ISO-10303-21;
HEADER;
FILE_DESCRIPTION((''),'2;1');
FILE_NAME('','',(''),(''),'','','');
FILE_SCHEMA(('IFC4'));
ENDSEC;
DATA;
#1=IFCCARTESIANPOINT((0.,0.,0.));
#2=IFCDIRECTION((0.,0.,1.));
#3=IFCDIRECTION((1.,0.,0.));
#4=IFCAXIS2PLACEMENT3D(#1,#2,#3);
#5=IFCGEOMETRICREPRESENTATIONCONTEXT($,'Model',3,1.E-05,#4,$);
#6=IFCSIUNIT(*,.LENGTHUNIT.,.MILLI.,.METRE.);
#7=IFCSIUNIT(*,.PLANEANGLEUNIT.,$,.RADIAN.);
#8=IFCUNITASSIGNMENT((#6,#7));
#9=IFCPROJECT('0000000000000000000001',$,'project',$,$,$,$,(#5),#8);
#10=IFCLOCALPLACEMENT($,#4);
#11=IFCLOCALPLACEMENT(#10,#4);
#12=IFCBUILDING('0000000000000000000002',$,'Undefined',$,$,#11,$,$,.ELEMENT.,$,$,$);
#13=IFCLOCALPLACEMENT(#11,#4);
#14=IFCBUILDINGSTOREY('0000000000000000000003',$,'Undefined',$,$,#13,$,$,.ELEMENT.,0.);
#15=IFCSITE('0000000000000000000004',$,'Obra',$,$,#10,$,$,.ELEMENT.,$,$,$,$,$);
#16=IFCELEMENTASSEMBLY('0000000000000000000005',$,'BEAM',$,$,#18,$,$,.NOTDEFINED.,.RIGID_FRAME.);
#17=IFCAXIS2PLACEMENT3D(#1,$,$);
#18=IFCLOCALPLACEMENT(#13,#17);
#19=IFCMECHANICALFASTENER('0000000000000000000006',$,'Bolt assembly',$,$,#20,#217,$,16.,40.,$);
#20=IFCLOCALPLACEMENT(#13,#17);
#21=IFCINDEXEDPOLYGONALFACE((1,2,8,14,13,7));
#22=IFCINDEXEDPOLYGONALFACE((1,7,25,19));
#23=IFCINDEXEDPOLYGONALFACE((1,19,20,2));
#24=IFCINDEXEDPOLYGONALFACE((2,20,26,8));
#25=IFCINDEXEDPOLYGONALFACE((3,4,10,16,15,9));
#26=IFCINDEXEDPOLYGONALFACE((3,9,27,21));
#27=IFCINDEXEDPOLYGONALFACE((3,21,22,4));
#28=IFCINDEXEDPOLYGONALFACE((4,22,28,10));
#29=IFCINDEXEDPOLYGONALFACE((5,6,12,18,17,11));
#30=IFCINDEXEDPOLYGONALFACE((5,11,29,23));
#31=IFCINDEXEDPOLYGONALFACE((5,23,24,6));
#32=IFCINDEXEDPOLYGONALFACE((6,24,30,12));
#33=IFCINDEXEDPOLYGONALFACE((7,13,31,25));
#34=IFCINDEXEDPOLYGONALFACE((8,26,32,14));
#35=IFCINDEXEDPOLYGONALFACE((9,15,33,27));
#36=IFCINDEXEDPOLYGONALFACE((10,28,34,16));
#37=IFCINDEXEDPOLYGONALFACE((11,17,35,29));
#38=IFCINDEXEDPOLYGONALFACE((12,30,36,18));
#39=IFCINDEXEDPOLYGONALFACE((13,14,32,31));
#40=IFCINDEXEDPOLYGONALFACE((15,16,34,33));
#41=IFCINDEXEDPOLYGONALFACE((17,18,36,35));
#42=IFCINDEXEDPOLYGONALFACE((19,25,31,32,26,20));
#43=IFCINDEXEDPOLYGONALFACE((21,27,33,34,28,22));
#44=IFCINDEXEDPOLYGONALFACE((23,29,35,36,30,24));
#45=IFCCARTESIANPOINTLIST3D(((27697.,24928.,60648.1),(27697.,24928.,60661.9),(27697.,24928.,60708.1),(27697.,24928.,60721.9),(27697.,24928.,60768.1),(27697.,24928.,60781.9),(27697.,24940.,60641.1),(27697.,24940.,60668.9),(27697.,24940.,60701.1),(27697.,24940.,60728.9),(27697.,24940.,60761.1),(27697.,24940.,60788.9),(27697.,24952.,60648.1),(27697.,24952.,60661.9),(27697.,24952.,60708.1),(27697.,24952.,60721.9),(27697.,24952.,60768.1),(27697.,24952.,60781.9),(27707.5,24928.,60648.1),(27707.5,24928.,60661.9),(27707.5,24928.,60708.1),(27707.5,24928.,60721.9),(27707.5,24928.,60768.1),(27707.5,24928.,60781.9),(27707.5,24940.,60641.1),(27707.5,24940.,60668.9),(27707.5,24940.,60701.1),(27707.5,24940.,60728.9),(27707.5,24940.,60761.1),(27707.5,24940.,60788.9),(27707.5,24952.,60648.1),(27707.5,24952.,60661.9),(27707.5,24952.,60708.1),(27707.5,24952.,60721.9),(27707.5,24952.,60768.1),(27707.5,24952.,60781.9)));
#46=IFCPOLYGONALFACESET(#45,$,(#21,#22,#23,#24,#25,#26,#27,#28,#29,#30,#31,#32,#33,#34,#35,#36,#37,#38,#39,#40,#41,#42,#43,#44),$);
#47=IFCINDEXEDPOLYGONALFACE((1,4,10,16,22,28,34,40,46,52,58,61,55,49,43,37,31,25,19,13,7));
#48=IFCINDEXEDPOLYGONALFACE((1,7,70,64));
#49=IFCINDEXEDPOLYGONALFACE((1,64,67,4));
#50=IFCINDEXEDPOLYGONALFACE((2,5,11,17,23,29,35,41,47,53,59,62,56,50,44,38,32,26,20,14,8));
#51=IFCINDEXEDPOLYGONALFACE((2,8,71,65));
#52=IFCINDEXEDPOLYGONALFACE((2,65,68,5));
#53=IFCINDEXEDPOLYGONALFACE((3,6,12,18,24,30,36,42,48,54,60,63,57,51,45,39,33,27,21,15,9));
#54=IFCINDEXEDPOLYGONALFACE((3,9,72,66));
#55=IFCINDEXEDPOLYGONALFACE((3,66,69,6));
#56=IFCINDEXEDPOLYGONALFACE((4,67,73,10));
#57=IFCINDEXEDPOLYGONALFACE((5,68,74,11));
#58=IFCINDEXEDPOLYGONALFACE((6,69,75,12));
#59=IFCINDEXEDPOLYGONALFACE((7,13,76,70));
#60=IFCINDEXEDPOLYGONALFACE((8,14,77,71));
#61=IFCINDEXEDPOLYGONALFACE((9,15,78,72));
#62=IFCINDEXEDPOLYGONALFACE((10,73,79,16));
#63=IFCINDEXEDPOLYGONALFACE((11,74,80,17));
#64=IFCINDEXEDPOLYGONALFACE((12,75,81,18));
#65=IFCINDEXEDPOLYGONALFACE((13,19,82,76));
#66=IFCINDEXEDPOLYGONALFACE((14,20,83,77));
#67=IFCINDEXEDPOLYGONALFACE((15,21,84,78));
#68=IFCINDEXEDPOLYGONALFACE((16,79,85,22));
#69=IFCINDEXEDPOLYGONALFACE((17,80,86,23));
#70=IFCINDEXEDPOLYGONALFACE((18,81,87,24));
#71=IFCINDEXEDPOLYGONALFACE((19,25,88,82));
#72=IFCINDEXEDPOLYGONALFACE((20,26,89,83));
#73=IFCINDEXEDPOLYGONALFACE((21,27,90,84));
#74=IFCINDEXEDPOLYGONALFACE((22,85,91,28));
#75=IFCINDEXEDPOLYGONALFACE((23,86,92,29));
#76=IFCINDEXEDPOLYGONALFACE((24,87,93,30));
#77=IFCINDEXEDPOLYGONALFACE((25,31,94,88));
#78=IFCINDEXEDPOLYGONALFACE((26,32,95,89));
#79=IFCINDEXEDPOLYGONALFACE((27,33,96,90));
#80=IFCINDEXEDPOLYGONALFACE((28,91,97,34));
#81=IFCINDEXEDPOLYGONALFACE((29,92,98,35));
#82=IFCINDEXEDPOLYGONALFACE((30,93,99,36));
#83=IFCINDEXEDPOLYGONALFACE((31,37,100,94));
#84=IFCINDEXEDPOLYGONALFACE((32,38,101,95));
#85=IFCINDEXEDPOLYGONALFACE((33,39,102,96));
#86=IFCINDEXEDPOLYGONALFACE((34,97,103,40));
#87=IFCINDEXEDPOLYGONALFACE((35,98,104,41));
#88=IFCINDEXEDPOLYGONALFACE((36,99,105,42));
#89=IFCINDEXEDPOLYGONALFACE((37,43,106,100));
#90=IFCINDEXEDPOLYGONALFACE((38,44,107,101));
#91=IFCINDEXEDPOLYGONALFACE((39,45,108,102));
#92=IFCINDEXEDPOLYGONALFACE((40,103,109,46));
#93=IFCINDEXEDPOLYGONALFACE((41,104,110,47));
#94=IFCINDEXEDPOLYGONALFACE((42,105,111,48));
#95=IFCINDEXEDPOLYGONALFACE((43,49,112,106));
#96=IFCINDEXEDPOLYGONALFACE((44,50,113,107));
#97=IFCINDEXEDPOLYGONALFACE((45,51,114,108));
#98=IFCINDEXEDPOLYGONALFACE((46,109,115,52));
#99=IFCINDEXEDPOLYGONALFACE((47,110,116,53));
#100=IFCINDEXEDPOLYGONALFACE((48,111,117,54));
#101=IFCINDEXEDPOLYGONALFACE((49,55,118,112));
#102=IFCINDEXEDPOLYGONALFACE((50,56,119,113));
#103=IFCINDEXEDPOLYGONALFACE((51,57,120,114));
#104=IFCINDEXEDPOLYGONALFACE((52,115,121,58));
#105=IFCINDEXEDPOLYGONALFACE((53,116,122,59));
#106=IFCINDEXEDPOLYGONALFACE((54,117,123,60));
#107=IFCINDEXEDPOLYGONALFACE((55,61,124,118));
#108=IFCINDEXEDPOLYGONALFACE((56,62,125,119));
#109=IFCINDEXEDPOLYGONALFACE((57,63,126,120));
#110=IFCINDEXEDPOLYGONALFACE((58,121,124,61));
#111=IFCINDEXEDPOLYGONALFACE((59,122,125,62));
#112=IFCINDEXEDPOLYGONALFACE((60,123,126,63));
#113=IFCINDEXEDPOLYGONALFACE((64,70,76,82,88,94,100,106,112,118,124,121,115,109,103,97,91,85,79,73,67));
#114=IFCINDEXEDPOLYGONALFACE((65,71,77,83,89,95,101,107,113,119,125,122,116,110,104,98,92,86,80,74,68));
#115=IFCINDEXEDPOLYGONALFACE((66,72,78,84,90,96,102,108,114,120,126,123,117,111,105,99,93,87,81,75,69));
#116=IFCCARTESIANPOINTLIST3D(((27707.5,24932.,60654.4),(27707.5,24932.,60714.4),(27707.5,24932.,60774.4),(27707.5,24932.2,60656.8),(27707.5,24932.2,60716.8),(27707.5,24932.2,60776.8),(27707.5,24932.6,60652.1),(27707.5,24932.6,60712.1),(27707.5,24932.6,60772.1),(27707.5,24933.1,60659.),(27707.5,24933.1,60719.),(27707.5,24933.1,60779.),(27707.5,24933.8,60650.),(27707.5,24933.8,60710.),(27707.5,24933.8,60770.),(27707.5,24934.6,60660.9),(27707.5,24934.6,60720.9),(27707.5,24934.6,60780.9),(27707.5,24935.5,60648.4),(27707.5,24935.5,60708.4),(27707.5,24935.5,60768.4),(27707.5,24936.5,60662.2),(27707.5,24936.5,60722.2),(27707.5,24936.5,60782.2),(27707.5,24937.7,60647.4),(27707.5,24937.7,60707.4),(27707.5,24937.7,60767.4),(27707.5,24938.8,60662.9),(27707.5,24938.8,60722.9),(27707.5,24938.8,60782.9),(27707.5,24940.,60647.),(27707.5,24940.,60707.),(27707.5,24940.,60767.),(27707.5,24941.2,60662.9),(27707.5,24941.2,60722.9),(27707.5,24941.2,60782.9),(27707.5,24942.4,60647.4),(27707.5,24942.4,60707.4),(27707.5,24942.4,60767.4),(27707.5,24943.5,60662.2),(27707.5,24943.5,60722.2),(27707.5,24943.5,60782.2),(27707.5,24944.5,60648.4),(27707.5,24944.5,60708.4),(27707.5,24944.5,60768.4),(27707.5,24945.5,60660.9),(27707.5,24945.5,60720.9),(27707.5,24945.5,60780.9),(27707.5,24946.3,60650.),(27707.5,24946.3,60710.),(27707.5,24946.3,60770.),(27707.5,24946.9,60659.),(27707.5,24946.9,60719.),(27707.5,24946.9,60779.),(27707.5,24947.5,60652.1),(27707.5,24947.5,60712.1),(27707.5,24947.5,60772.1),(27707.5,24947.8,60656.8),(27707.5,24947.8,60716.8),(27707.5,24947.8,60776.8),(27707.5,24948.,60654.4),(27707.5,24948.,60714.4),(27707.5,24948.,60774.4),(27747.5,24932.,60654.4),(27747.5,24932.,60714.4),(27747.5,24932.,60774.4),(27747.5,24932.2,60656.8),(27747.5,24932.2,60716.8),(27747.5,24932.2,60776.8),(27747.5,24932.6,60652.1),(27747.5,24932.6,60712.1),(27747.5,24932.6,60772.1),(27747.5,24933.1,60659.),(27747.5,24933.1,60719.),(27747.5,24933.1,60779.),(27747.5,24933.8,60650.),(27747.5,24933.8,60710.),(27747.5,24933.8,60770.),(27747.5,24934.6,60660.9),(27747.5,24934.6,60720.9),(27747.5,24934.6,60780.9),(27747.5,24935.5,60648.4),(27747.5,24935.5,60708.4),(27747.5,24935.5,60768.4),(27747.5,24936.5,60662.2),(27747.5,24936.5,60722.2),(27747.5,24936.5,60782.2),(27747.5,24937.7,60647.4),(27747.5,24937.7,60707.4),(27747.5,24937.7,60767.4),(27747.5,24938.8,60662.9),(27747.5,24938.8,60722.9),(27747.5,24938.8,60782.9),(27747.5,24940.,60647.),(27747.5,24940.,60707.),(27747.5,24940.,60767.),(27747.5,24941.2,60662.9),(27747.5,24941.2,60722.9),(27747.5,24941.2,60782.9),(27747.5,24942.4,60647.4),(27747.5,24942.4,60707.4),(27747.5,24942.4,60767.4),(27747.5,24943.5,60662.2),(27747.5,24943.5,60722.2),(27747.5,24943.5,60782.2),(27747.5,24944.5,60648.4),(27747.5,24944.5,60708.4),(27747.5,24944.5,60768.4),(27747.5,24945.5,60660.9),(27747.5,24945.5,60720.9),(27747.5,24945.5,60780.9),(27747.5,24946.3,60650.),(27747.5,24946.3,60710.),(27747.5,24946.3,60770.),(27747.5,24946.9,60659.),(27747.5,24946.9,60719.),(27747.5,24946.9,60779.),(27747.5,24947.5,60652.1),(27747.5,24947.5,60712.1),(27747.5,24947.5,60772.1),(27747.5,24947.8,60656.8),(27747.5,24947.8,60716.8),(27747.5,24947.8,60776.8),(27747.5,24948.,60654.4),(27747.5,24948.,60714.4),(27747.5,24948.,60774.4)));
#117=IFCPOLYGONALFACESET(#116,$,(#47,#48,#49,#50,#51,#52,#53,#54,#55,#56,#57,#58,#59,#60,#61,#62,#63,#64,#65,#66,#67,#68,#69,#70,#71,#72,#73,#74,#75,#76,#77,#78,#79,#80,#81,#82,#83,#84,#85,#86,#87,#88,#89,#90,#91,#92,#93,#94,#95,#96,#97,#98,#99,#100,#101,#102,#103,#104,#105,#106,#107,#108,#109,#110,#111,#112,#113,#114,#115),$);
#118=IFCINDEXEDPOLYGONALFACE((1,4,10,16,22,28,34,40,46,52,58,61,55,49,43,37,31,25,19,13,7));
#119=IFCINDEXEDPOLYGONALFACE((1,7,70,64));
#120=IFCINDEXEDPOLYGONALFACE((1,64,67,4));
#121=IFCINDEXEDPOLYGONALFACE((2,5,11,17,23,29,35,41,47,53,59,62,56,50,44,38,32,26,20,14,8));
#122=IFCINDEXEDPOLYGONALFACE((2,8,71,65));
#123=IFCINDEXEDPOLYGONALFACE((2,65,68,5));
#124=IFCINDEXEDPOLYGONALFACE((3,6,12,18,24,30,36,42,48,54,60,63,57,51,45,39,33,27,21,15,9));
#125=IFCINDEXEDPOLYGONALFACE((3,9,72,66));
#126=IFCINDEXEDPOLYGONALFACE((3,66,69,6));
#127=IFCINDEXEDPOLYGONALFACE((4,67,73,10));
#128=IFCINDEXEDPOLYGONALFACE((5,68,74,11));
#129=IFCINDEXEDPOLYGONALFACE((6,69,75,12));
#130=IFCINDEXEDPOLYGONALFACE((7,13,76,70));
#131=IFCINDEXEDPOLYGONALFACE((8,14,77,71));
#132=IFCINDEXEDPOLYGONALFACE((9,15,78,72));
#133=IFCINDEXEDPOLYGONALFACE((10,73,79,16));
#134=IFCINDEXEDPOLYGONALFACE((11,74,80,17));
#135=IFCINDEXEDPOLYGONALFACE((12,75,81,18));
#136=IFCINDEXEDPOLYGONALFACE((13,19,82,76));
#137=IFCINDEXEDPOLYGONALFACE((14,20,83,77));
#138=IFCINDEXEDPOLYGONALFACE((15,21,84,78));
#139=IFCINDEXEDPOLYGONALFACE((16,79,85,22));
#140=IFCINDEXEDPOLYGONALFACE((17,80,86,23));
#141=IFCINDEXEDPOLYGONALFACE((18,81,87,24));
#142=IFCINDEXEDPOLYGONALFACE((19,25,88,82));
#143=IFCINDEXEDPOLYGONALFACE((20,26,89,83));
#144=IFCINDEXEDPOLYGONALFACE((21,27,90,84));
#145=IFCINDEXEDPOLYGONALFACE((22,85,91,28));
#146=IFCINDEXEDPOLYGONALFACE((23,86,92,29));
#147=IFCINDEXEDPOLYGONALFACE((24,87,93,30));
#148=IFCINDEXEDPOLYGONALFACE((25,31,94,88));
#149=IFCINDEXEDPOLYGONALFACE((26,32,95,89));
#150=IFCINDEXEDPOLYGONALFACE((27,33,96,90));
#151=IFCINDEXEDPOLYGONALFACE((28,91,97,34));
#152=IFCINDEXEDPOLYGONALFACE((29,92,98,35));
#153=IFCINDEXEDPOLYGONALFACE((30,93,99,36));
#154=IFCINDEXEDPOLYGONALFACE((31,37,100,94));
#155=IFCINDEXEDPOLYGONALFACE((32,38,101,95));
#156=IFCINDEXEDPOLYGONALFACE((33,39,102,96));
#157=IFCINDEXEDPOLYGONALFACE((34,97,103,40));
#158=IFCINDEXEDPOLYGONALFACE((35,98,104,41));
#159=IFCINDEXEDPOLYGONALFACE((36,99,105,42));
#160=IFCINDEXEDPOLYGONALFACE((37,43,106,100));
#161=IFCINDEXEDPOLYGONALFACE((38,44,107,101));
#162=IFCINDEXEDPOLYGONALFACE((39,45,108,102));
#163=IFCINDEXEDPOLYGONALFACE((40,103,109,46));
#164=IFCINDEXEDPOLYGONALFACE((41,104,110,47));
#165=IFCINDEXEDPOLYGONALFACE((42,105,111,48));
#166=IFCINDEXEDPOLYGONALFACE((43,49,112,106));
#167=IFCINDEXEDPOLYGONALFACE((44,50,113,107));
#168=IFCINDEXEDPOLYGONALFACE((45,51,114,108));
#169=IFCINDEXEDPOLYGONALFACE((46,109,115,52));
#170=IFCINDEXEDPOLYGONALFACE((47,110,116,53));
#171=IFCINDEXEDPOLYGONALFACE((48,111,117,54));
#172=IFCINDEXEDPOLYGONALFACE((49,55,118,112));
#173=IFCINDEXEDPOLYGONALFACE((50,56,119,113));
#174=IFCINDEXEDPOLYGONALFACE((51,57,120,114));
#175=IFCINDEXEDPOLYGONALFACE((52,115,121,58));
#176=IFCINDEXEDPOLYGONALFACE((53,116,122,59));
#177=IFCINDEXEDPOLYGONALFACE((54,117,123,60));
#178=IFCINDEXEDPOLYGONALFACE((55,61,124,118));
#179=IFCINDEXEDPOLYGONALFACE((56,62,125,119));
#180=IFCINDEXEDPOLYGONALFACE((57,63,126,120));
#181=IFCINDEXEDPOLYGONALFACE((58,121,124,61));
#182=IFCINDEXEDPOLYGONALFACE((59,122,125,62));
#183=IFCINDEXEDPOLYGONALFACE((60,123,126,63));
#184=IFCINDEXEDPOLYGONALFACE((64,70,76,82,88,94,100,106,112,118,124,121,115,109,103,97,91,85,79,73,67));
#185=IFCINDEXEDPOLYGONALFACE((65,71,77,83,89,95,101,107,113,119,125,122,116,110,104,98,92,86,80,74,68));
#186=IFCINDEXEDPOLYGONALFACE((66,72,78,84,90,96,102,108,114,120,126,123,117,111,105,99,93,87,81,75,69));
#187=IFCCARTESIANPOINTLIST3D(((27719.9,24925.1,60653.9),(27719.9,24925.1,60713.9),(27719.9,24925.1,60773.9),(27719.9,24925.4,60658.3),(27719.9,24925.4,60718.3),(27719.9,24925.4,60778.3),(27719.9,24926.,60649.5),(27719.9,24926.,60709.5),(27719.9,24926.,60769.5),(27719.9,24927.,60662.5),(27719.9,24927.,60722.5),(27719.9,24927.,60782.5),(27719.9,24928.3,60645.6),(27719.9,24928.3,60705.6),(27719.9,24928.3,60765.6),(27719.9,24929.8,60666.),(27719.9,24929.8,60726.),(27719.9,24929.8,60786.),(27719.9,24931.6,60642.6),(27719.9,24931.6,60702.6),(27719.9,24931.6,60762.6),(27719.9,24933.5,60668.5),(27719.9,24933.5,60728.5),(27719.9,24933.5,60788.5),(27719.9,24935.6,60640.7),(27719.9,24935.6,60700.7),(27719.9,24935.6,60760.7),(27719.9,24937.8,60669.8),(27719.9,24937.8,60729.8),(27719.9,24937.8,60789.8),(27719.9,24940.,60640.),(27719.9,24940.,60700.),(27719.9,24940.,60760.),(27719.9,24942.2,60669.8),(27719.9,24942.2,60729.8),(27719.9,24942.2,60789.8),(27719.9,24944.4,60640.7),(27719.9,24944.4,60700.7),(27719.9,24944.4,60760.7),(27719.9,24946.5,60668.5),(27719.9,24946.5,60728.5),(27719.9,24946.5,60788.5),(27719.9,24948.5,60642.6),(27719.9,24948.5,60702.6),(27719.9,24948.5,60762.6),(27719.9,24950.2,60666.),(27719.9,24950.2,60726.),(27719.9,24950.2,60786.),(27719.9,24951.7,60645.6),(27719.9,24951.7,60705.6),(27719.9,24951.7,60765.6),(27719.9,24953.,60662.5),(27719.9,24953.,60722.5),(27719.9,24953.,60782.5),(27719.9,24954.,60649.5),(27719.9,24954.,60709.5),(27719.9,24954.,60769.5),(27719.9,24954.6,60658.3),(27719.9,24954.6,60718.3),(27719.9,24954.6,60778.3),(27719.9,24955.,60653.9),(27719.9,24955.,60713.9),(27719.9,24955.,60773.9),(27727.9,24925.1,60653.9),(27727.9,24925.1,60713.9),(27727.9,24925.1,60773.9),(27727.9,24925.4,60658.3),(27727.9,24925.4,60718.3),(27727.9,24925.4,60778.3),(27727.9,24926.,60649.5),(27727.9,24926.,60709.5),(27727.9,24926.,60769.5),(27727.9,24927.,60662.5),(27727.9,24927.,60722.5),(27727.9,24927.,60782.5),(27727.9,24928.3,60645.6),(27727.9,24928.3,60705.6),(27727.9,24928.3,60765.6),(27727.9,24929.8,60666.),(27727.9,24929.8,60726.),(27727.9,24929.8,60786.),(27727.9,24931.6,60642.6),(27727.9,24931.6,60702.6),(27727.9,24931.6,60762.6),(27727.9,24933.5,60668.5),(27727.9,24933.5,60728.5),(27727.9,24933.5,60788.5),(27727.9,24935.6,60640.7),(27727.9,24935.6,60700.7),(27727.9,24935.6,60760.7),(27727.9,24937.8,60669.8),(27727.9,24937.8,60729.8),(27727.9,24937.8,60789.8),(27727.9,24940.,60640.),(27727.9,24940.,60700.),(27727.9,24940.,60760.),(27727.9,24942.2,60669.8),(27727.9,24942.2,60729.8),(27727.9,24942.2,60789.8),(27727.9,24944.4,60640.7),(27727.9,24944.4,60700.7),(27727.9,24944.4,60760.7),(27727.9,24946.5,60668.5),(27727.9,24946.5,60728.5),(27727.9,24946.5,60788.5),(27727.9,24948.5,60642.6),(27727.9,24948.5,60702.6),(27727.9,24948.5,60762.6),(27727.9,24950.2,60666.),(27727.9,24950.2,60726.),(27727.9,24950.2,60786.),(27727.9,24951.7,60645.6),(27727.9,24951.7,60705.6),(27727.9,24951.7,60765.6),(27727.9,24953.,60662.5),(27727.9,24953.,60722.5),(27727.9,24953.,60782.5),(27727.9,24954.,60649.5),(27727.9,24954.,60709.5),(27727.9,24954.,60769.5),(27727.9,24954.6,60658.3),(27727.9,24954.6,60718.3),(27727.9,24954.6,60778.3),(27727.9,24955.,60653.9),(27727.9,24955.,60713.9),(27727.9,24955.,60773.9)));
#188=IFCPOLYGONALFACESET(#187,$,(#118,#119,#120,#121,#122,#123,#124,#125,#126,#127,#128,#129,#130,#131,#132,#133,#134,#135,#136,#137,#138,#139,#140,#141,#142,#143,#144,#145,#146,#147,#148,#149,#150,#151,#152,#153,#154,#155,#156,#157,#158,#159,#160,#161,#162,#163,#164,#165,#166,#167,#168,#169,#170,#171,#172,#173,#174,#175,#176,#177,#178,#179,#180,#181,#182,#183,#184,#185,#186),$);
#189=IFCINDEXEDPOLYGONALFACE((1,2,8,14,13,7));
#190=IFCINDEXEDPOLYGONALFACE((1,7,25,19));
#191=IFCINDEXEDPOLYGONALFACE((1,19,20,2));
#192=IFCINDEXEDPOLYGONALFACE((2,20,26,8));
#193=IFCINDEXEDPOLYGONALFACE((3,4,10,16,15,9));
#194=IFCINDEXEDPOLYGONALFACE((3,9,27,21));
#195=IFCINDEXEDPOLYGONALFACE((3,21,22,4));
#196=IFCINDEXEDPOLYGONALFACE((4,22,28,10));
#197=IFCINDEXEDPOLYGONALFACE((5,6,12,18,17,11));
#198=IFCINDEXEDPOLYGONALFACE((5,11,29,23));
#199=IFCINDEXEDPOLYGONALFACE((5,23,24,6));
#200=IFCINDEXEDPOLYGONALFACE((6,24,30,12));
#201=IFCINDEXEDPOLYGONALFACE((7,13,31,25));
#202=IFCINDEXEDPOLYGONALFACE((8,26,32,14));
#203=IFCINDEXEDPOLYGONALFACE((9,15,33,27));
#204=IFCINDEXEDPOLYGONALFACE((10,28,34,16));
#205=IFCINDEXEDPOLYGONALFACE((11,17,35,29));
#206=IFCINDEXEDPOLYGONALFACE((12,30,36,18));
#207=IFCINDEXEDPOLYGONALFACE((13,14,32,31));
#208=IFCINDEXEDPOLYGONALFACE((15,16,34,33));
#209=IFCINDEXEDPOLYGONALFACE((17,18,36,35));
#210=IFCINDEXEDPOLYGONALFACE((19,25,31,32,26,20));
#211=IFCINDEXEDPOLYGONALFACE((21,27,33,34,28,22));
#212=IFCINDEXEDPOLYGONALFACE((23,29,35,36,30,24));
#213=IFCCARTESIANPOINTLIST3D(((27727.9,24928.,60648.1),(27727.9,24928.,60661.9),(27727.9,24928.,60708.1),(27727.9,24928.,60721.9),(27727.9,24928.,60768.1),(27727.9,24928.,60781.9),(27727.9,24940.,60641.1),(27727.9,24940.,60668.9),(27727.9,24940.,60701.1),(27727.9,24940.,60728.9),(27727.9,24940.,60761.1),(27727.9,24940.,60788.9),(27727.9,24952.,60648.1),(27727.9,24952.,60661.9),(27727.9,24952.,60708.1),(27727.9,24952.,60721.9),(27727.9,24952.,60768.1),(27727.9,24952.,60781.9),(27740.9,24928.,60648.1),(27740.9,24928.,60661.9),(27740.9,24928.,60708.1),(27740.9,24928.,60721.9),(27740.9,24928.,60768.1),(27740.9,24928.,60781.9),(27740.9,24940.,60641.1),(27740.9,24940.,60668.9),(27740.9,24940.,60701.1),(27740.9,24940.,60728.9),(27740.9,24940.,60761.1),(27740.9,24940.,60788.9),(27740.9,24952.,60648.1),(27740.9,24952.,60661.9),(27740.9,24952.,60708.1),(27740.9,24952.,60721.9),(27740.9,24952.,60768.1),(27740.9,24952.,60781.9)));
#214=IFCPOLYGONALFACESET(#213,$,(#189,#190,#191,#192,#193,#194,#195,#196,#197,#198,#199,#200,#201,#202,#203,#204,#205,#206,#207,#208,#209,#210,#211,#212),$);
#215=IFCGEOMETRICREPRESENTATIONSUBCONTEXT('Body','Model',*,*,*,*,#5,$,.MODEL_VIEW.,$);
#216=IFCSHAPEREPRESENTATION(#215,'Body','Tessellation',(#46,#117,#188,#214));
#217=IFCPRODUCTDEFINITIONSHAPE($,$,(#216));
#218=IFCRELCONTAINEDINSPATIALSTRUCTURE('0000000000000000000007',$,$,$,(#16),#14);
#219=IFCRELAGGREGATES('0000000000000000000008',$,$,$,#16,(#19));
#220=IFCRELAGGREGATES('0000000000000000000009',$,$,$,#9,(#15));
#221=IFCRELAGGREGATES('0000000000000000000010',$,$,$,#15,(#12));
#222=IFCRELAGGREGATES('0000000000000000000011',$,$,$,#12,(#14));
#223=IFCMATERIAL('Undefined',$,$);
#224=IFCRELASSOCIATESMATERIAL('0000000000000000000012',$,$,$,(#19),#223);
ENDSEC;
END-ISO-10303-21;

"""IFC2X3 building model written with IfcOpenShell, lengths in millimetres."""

from ifc_helpers import new_model, si_unit, frame, origin_with_axes, origin_2d_with_axis, place, context, subcontext, project, spatial, polyline, circle, outline, extrude, source, transform, mapped, material, element, aggregate, save


model = new_model("IFC2X3")

# Units and contexts
model_context = context("Model", 3, precision=1e-05, world=origin_with_axes())
body_context = subcontext(model_context, "Body", "Model", "MODEL_VIEW")
ifc_project = project(units=[si_unit("LENGTHUNIT", "METRE", prefix="MILLI"), si_unit("PLANEANGLEUNIT", "RADIAN")], contexts=[model_context])

# Site, building, storey
site_placement = place(None, origin_with_axes())
site = spatial("IfcSite", under=ifc_project, at=site_placement, Name="Obra", CompositionType="ELEMENT")
building_placement = place(site_placement, origin_with_axes())
building = spatial("IfcBuilding", under=site, at=building_placement, Name="Undefined", CompositionType="ELEMENT")
storey_placement = place(building_placement, origin_with_axes())
storey = spatial("IfcBuildingStorey", under=building, at=storey_placement, Name="Undefined", CompositionType="ELEMENT", Elevation=0.0)

# Shared definitions
ifc_material_1 = material(Name="Undefined")

# Element assembly, mechanical fastener
assembly_1_placement = place(storey_placement, origin_with_axes())
assembly_1 = element("IfcElementAssembly", 1, at=assembly_1_placement, inside=storey, Name="BEAM", AssemblyPlace="NOTDEFINED", PredefinedType="RIGID_FRAME")
shared_shape_1 = source(origin_with_axes(), body_context, "Body", "SweptSolid", [
    extrude(outline(polyline([(13.9, 0.0), (6.9, 12.0), (-6.9, 12.0), (-13.9, 0.0), (-6.9, -12.0), (6.9, -12.0), (13.9, 0.0)])), frame((0.0, -19.7, 0.0), z_axis=(0.0, 1.0, 0.0), x_axis=(1.0, 0.0, 0.0)), (0.0, 0.0, 1.0), 10.6),
    extrude(circle(Radius=8.0, at=origin_2d_with_axis()), frame((0.0, -9.1, 0.0), z_axis=(0.0, 1.0, 0.0), x_axis=(1.0, 0.0, 0.0)), (0.0, 0.0, 1.0), 40.0),
    extrude(circle(Radius=15.0, at=origin_2d_with_axis()), frame((0.0, 3.3, 0.0), z_axis=(0.0, 1.0, 0.0), x_axis=(1.0, 0.0, 0.0)), (0.0, 0.0, 1.0), 8.0),
    extrude(outline(polyline([(13.9, 0.0), (6.9, 12.0), (-6.9, 12.0), (-13.9, 0.0), (-6.9, -12.0), (6.9, -12.0), (13.9, 0.0)])), frame((0.0, 11.3, 0.0), z_axis=(0.0, 1.0, 0.0), x_axis=(1.0, 0.0, 0.0)), (0.0, 0.0, 1.0), 13.0),
])
mechanical_fastener_1_placement = place(assembly_1_placement, frame((27716.6, 24990.0, 60835.0), z_axis=(0.000002, -1.0, 0.0), x_axis=(0.0, 0.0, -1.0)))
mechanical_fastener_1 = element("IfcMechanicalFastener", 2, at=mechanical_fastener_1_placement, material=ifc_material_1, Name="Bolt assembly", NominalDiameter=16.0, NominalLength=40.0, context=body_context, shape_type="MappedRepresentation", body=[
    mapped(shared_shape_1, transform((60.0, 0.0, 50.0))),
    mapped(shared_shape_1, transform((120.0, 0.0, 50.0))),
    mapped(shared_shape_1, transform((180.0, 0.0, 50.0))),
])
aggregate(assembly_1, [mechanical_fastener_1])

save(model, "model.ifc")
